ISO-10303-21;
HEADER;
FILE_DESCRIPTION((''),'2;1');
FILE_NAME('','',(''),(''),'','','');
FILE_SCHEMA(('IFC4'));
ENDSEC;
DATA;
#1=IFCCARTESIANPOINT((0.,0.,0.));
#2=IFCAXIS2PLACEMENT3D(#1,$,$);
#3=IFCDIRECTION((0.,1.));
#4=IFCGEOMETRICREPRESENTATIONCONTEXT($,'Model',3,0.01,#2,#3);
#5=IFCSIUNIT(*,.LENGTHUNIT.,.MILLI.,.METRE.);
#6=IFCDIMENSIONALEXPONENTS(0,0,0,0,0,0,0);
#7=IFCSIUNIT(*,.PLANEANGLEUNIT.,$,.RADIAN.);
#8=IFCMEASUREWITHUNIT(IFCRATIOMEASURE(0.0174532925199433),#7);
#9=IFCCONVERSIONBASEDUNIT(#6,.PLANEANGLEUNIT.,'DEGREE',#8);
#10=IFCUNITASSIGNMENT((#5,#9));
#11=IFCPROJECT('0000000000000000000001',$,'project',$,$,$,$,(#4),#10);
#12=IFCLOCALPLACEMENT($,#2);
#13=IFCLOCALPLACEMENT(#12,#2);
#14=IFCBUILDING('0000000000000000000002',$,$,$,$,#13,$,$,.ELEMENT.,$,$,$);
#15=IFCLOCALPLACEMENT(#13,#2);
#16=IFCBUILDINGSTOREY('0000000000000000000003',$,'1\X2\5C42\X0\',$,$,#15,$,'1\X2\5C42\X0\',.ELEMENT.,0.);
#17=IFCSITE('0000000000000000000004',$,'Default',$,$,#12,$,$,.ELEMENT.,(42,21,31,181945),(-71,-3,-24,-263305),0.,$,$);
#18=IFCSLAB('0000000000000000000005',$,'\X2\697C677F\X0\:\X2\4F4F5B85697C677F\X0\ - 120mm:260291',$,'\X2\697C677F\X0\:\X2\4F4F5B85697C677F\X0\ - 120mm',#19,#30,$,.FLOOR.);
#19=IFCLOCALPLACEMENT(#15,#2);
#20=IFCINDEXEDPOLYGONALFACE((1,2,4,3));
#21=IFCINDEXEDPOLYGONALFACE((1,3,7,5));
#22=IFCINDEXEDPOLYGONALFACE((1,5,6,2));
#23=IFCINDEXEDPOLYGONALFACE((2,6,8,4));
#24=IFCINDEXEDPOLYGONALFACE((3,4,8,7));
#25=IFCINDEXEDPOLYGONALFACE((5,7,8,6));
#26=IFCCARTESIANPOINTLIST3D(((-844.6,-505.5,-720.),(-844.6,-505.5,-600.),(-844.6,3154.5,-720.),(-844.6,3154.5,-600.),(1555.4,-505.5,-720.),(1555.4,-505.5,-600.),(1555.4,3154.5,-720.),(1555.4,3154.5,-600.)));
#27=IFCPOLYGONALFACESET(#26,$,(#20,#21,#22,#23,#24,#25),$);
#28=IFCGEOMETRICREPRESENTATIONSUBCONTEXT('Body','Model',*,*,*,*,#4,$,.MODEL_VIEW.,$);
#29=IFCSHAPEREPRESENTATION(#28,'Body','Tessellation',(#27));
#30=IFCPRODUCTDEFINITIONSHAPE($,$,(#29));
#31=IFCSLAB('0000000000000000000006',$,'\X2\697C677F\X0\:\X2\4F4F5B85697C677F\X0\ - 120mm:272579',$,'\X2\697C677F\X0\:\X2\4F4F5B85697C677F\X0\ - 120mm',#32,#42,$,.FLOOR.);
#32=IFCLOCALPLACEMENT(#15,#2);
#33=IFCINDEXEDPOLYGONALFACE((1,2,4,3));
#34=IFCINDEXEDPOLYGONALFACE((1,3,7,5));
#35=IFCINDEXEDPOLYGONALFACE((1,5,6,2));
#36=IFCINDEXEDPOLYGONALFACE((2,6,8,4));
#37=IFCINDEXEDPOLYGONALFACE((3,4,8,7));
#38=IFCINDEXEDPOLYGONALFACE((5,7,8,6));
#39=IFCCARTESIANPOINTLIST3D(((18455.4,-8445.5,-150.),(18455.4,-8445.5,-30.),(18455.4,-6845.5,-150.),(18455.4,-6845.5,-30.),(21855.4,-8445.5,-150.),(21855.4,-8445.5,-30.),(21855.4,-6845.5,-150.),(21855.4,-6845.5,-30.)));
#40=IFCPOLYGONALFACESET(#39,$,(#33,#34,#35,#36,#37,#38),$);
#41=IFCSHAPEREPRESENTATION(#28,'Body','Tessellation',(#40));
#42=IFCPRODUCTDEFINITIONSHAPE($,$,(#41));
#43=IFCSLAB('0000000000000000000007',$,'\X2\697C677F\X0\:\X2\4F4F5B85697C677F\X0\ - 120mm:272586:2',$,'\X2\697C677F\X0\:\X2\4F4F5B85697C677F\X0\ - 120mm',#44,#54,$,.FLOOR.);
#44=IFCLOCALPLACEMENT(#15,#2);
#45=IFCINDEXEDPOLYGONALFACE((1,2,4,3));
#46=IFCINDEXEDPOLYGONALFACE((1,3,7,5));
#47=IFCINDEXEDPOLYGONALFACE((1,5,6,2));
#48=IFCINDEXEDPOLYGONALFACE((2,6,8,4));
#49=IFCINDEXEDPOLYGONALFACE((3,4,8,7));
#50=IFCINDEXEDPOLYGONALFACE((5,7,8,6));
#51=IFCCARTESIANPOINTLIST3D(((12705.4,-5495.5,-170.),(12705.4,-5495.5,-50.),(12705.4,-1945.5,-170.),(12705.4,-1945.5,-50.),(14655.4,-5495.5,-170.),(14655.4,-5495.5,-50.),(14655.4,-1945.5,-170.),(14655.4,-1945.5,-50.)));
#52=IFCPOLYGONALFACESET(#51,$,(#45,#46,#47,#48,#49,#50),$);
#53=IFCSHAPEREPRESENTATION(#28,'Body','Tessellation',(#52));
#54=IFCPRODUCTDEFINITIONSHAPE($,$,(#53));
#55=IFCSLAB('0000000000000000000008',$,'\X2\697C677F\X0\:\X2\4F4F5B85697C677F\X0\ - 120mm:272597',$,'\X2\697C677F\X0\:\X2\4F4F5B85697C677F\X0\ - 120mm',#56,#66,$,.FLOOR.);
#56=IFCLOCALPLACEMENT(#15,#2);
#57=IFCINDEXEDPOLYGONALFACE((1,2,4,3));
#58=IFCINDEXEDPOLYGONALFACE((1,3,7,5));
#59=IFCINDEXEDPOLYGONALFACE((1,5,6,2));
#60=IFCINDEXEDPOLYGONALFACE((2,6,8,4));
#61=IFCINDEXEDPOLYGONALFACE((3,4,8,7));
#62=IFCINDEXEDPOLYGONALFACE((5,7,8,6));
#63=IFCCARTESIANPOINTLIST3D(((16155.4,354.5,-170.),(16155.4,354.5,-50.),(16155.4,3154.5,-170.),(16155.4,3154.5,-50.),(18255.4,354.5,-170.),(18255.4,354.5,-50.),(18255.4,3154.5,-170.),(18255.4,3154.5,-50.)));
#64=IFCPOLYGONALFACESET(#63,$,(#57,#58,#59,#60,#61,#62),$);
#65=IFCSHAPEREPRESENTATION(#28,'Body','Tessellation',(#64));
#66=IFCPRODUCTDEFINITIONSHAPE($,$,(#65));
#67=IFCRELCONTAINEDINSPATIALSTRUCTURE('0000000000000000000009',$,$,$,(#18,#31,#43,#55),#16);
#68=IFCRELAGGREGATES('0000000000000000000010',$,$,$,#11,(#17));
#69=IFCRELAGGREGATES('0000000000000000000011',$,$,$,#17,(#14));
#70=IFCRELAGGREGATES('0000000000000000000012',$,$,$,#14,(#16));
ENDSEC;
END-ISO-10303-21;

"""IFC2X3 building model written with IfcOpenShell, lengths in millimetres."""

from ifc_helpers import new_model, entity, si_unit, converted_unit, direction, frame, frame_2d, origin, origin_2d_with_axis, place, context, subcontext, project, spatial, rectangle, extrude, element, save


model = new_model("IFC2X3")

# Units and contexts
model_context = context("Model", 3, precision=0.01, world=origin(), true_north=direction((0.0, 1.0)))
body_context = subcontext(model_context, "Body", "Model", "MODEL_VIEW")
ifc_project = project(units=[si_unit("LENGTHUNIT", "METRE", prefix="MILLI"), converted_unit("PLANEANGLEUNIT", "DEGREE", entity("IfcRatioMeasure", 0.0174532925199433), si_unit("PLANEANGLEUNIT", "RADIAN"), dimensions=[0, 0, 0, 0, 0, 0, 0])], contexts=[model_context])

# Site, building, storey
site_placement = place(None, origin())
site = spatial("IfcSite", under=ifc_project, at=site_placement, Name="Default", CompositionType="ELEMENT", RefLatitude=(42, 21, 31, 181945), RefLongitude=(-71, -3, -24, -263305), RefElevation=0.0)
building_placement = place(site_placement, origin())
building = spatial("IfcBuilding", under=site, at=building_placement, CompositionType="ELEMENT")
storey_placement = place(building_placement, origin())
storey = spatial("IfcBuildingStorey", under=building, at=storey_placement, Name="1层", LongName="1层", CompositionType="ELEMENT", Elevation=0.0)

# Slabs
slab_1_placement = place(storey_placement, origin())
element("IfcSlab", 1, at=slab_1_placement, inside=storey, Name="楼板:住宅楼板 - 120mm:260291", ObjectType="楼板:住宅楼板 - 120mm", PredefinedType="FLOOR", context=body_context, shape_type="SweptSolid", body=[
    extrude(rectangle(XDim=3660.0, YDim=2400.0, at=frame_2d((0.0, 0.0), x_axis=(1.0, 0.0))), frame((355.4, 1324.5, -600.0), z_axis=(0.0, 0.0, -1.0), x_axis=(0.0, 1.0, 0.0)), (0.0, 0.0, 1.0), 120.0),
])
slab_2_placement = place(storey_placement, origin())
element("IfcSlab", 2, at=slab_2_placement, inside=storey, Name="楼板:住宅楼板 - 120mm:272579", ObjectType="楼板:住宅楼板 - 120mm", PredefinedType="FLOOR", context=body_context, shape_type="SweptSolid", body=[
    extrude(rectangle(XDim=1600.0, YDim=3400.0, at=frame_2d((0.0, 0.0), x_axis=(1.0, 0.0))), frame((20155.4, -7645.5, -30.0), z_axis=(0.0, 0.0, -1.0), x_axis=(0.0, 1.0, 0.0)), (0.0, 0.0, 1.0), 120.0),
])
slab_3_placement = place(storey_placement, frame((12705.4, -5495.5, -170.0)))
element("IfcSlab", 3, at=slab_3_placement, inside=storey, Name="楼板:住宅楼板 - 120mm:272586:2", ObjectType="楼板:住宅楼板 - 120mm", PredefinedType="FLOOR", context=body_context, shape_type="SweptSolid", body=[
    extrude(rectangle(XDim=1950.0, YDim=3550.0, at=frame_2d((1075.0, 0.0), x_axis=(-1.0, 0.0))), frame((2050.0, 1775.0, 120.0), z_axis=(0.0, 0.0, -1.0), x_axis=(-1.0, 0.0, 0.0)), (0.0, 0.0, 1.0), 120.0),
])
slab_4_placement = place(storey_placement, origin())
element("IfcSlab", 4, at=slab_4_placement, inside=storey, Name="楼板:住宅楼板 - 120mm:272597", ObjectType="楼板:住宅楼板 - 120mm", PredefinedType="FLOOR", context=body_context, shape_type="SweptSolid", body=[
    extrude(rectangle(XDim=2800.0, YDim=2100.0, at=origin_2d_with_axis()), frame((17205.4, 1754.5, -50.0), z_axis=(0.0, 0.0, -1.0), x_axis=(0.0, 1.0, 0.0)), (0.0, 0.0, 1.0), 120.0),
])

save(model, "model.ifc")
